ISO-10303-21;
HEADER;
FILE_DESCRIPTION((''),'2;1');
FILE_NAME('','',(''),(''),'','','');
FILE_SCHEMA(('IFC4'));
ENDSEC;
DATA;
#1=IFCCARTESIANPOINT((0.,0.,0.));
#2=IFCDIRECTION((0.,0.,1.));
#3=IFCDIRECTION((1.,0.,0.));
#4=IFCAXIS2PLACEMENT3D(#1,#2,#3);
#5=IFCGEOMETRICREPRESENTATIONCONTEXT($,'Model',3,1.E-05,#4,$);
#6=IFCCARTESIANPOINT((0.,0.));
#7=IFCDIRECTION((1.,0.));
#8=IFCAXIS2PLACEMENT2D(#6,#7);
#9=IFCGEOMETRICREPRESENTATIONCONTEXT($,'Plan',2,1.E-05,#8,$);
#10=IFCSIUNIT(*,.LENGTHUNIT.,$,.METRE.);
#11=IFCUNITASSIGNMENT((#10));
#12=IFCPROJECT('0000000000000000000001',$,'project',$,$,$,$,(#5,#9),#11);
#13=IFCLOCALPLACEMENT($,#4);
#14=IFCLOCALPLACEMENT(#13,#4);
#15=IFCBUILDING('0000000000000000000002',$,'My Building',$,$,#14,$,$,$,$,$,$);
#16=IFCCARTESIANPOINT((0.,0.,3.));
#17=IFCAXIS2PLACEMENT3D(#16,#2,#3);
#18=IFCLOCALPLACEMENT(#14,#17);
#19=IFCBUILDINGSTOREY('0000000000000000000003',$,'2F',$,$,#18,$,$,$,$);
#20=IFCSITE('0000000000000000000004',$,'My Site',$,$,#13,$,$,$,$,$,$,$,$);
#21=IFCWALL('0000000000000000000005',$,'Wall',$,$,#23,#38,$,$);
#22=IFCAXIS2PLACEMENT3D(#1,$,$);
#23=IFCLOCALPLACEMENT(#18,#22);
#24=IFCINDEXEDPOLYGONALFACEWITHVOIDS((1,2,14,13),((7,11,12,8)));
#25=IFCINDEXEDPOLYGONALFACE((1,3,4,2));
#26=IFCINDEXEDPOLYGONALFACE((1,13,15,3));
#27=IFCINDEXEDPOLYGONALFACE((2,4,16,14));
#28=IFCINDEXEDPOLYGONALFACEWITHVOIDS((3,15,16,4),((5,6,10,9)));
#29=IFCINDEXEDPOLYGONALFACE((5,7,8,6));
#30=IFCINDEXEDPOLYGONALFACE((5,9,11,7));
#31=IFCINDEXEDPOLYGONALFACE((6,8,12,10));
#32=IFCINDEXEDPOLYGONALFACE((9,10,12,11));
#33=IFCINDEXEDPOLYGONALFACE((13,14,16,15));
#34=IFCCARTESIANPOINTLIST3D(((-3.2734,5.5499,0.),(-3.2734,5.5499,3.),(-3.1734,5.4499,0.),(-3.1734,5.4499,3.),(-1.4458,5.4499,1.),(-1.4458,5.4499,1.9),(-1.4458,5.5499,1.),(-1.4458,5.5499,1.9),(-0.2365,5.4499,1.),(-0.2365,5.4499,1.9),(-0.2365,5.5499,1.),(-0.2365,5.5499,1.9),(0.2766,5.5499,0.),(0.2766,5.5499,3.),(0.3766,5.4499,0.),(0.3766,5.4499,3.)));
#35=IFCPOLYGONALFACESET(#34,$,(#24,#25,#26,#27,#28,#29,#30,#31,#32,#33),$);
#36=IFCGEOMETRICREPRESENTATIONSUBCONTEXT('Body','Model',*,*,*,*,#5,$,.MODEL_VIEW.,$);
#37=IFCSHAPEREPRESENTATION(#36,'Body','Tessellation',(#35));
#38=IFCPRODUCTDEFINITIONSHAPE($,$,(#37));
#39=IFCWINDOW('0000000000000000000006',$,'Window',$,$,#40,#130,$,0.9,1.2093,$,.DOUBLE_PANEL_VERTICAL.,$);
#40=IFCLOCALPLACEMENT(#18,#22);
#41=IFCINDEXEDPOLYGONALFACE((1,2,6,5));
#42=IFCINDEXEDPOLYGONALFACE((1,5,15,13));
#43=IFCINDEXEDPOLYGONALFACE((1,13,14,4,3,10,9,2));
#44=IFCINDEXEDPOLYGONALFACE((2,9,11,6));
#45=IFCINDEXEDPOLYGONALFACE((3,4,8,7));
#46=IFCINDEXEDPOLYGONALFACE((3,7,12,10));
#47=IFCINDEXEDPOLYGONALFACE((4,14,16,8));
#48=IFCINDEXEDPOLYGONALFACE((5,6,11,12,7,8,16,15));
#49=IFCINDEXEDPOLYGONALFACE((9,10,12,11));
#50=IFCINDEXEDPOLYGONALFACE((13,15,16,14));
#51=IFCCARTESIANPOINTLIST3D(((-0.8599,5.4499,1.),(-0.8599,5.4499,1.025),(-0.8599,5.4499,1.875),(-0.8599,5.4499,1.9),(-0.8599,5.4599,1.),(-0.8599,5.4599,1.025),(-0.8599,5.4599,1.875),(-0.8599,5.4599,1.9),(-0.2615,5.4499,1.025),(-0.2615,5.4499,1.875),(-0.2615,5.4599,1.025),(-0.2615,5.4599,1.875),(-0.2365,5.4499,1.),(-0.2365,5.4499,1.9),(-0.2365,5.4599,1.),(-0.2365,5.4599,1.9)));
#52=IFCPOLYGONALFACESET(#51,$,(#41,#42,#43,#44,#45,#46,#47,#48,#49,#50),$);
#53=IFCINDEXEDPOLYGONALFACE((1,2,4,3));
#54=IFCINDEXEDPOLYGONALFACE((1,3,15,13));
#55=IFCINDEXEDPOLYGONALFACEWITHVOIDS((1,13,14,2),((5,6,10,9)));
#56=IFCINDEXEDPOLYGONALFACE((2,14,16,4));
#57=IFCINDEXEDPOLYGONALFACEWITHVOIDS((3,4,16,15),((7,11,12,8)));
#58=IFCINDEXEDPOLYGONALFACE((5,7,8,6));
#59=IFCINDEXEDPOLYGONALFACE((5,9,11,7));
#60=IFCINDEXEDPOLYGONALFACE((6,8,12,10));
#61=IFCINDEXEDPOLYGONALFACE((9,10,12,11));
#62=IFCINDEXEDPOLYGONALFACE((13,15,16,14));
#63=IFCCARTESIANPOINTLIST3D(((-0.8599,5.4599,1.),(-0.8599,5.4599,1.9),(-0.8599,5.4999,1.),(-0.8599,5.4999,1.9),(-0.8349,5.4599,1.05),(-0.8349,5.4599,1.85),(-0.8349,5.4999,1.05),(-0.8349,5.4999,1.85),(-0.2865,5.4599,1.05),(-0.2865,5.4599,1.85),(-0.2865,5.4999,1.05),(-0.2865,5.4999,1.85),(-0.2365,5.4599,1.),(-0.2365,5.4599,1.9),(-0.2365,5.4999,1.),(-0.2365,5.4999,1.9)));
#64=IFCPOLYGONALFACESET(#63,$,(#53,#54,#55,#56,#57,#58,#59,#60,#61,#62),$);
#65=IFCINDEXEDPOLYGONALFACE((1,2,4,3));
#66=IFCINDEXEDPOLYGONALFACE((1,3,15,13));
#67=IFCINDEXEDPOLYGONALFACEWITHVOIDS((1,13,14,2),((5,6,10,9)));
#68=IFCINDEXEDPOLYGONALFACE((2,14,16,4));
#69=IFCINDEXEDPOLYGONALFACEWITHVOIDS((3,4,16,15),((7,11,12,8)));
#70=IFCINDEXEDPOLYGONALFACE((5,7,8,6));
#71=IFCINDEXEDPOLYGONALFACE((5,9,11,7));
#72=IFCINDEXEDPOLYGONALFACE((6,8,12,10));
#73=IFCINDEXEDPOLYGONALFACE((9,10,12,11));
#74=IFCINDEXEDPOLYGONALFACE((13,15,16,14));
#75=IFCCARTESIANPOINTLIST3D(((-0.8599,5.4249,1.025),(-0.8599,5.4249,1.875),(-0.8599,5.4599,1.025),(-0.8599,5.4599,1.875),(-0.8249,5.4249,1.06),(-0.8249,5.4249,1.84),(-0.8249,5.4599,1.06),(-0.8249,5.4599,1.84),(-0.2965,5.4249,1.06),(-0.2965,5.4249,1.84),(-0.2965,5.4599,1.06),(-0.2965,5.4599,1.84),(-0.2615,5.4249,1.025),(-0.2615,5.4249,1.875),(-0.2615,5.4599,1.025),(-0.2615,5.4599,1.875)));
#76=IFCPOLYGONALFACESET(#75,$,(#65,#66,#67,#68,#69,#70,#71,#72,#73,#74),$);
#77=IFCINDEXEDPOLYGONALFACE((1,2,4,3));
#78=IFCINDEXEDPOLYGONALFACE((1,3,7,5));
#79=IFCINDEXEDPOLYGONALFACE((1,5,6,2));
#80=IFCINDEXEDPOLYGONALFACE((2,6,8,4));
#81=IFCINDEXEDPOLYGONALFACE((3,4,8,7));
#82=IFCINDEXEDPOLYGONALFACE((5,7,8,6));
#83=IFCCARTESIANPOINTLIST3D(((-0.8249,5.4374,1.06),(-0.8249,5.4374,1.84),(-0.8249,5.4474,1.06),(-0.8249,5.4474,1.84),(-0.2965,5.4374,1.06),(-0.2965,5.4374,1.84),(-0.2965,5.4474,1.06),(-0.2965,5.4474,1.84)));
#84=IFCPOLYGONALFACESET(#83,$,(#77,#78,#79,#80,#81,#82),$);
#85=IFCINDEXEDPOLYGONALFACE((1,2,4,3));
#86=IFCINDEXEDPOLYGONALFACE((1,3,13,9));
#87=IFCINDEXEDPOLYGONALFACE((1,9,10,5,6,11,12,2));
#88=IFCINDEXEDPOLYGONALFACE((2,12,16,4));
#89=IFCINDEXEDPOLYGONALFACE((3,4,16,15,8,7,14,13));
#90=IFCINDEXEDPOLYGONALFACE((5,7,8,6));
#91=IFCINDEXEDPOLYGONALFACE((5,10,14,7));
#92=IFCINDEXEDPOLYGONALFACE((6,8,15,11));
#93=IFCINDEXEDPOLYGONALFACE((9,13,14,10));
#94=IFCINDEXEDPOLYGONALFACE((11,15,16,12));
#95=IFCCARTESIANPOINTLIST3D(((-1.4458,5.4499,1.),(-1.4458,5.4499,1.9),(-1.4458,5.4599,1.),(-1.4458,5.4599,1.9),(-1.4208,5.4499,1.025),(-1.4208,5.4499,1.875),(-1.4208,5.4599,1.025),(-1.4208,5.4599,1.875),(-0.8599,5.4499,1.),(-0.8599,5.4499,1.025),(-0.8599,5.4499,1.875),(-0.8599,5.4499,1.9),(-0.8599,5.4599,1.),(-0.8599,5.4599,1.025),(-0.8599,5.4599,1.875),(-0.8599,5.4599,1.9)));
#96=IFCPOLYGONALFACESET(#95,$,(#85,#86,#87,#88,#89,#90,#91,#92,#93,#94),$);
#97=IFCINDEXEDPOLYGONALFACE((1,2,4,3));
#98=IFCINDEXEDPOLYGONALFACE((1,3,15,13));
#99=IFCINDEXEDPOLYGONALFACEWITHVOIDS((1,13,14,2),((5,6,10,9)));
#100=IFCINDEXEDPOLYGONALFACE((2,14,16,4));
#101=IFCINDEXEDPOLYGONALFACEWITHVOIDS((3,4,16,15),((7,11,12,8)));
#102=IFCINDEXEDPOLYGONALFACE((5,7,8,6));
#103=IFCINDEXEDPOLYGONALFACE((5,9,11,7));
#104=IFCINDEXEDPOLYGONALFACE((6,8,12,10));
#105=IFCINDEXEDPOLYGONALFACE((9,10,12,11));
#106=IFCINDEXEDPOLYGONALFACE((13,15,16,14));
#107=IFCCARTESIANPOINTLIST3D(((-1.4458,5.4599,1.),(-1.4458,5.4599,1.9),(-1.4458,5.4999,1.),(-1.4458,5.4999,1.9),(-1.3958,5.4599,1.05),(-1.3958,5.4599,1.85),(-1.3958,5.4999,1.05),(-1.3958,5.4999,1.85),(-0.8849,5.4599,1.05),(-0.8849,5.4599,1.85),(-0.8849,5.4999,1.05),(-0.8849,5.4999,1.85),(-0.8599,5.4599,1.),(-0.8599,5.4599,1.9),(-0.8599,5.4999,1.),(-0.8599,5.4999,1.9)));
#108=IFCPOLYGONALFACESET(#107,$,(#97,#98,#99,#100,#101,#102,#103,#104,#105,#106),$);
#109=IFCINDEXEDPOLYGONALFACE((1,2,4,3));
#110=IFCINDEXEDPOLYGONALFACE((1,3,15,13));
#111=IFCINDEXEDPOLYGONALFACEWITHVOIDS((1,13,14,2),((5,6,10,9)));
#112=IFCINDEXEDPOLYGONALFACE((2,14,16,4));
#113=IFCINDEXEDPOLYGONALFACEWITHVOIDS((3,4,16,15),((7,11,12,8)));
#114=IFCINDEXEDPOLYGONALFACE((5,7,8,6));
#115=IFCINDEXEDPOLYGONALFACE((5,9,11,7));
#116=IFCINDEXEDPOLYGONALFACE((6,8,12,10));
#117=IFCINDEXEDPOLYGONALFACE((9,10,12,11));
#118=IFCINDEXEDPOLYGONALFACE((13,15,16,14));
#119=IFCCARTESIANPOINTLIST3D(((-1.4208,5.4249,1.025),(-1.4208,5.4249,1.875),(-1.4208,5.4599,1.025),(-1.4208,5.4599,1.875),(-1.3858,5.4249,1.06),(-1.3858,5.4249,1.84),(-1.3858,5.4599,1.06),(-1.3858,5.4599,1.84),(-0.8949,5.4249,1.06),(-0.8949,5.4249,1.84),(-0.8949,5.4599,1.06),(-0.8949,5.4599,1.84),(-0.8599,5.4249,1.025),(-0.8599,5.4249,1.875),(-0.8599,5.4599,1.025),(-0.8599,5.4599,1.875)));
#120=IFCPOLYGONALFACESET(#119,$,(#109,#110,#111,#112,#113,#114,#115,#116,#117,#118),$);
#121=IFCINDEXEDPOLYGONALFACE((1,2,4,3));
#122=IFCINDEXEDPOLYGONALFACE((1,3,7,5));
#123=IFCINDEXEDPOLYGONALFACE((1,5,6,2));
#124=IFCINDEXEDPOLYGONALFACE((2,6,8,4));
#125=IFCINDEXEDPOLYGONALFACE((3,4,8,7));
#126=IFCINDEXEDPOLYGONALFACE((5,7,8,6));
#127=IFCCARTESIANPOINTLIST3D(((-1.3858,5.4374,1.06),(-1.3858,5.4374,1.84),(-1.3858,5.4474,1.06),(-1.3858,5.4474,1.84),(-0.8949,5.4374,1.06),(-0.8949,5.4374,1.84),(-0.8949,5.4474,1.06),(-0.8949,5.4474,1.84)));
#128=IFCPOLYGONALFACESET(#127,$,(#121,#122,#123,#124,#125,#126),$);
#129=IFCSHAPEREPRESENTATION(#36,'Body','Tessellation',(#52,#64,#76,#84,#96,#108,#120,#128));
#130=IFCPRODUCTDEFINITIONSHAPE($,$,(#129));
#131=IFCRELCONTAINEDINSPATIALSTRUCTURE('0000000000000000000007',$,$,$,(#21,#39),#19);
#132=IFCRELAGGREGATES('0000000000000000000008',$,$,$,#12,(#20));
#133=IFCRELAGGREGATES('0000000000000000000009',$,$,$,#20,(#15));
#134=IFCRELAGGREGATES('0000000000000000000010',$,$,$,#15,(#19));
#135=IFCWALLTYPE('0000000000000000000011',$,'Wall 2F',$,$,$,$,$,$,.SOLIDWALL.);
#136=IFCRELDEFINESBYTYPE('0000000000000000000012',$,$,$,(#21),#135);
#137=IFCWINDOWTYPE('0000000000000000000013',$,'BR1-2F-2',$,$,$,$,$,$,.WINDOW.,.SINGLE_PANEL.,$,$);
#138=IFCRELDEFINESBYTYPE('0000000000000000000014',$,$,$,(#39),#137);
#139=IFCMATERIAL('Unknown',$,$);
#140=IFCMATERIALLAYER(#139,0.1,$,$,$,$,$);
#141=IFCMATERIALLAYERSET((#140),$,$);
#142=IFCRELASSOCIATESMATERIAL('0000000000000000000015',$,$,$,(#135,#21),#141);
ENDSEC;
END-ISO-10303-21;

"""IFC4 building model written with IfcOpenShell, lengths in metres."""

from ifc_helpers import new_model, entity, si_unit, frame, origin_with_axes, origin_2d_with_axis, place, context, subcontext, project, spatial, line, indexed_curve, outline, extrude, shape, source, transform, mapped, material, layer, layer_set, layer_usage, type_object, type_shapes, element, fill, save


model = new_model("IFC4")

# Units and contexts
model_context = context("Model", 3, precision=1e-05, world=origin_with_axes())
plan_context = context("Plan", 2, precision=1e-05, world=origin_2d_with_axis())
body_context_1 = subcontext(model_context, "Body", "Model", "MODEL_VIEW")
body_context_2 = subcontext(plan_context, "Body", "Plan", "PLAN_VIEW")
ifc_project = project(units=[si_unit("LENGTHUNIT", "METRE")], contexts=[model_context, plan_context])

# Site, building, storey
site_placement = place(None, origin_with_axes())
site = spatial("IfcSite", under=ifc_project, at=site_placement, Name="My Site")
building_placement = place(site_placement, origin_with_axes())
building = spatial("IfcBuilding", under=site, at=building_placement, Name="My Building")
storey_placement = place(building_placement, frame((0.0, 0.0, 3.0), z_axis=(0.0, 0.0, 1.0), x_axis=(1.0, 0.0, 0.0)))
storey = spatial("IfcBuildingStorey", under=building, at=storey_placement, Name="2F")

# Shared definitions
ifc_material = material(Name="Unknown")

# Shared definitions
ifc_layer_1 = layer(ifc_material, 0.1)
ifc_layer_set_1 = layer_set([ifc_layer_1])
wall_type = type_object("IfcWallType", Name="Wall 2F", PredefinedType="SOLIDWALL", material=ifc_layer_set_1)

# Wall, opening, window
ifc_layer_usage_1 = layer_usage(ifc_layer_set_1, "AXIS2", "POSITIVE", 0.0)
wall_1_placement = place(storey_placement, frame((0.2766, 5.5499, 0.0), z_axis=(0.0, 0.0, 1.0), x_axis=(-1.0, 0.0, 0.0)))
wall_1 = element("IfcWall", 1, at=wall_1_placement, inside=storey, type_object=wall_type, material=ifc_layer_usage_1, Name="Wall", context=body_context_1, shape_type="SweptSolid", body=[
    extrude(outline(indexed_curve([(0.0, 0.0), (-0.1, 0.1), (3.45, 0.1), (3.55, 0.0)], segments=[line(1, 2, 3, 4, 1)])), origin_with_axes(), (0.0, 0.0, 1.0), 3.0),
])
shared_shape_1 = source(origin_with_axes(), body_context_1, "Body", "SweptSolid", [
    extrude(outline(indexed_curve([(0.0, 0.0), (1.2093, 0.0), (1.2093, 0.9), (0.0, 0.9)], segments=[line(1, 2, 3, 4, 1)])), frame((0.0, -0.6, 0.0), z_axis=(0.0, -1.0, 0.0), x_axis=(1.0, 0.0, 0.0)), (0.0, 0.0, -1.0), 1.2),
])
opening_1_placement = place(wall_1_placement, frame((0.5131, 0.0, 1.0), z_axis=(0.0, 0.0, 1.0), x_axis=(1.0, 0.0, 0.0)))
opening_1 = element("IfcOpeningElement", 2, at=opening_1_placement, cuts=wall_1, PredefinedType="OPENING", context=body_context_1, shape_type="MappedRepresentation", body=[
    mapped(shared_shape_1, transform((0.0, 0.0, 0.0), x_axis=(1.0, 0.0, 0.0), y_axis=(0.0, 1.0, 0.0), z_axis=(0.0, 0.0, 1.0), scale=1.0)),
])
window_type_1 = type_object("IfcWindowType", Name="BR1-2F-2", PartitioningType="SINGLE_PANEL", PredefinedType="WINDOW")
shared_shape_2 = source(origin_with_axes(), body_context_1, "Body", "SweptSolid", [
    extrude(outline(indexed_curve([(0.6234, 0.0), (0.0, 0.0), (0.0, 0.9), (0.6234, 0.9), (0.6234, 0.875), (0.025, 0.875), (0.025, 0.025), (0.6234, 0.025)], segments=[line(1, 2, 3, 4, 5, 6, 7, 8, 1)])), frame((0.0, 0.09, 0.0), z_axis=(0.0, -1.0, 0.0), x_axis=(1.0, 0.0, 0.0)), (0.0, 0.0, -1.0), 0.01),
    extrude(outline(indexed_curve([(0.0, 0.0), (0.6234, 0.0), (0.6234, 0.9), (0.0, 0.9)], segments=[line(1, 2, 3, 4, 1)]), holes=[indexed_curve([(0.05, 0.05), (0.5984, 0.05), (0.5984, 0.85), (0.05, 0.85)], segments=[line(1, 2, 3, 4, 1)])]), frame((0.0, 0.05, 0.0), z_axis=(0.0, -1.0, 0.0), x_axis=(1.0, 0.0, 0.0)), (0.0, 0.0, -1.0), 0.04),
    extrude(outline(indexed_curve([(0.0, 0.0), (0.5984, 0.0), (0.5984, 0.85), (0.0, 0.85)], segments=[line(1, 2, 3, 4, 1)]), holes=[indexed_curve([(0.035, 0.035), (0.5634, 0.035), (0.5634, 0.815), (0.035, 0.815)], segments=[line(1, 2, 3, 4, 1)])]), frame((0.025, 0.09, 0.025), z_axis=(0.0, -1.0, 0.0), x_axis=(1.0, 0.0, 0.0)), (0.0, 0.0, -1.0), 0.035),
    extrude(outline(indexed_curve([(0.035, 0.035), (0.5634, 0.035), (0.5634, 0.815), (0.035, 0.815)], segments=[line(1, 2, 3, 4, 1)])), frame((0.025, 0.1025, 0.025), z_axis=(0.0, -1.0, 0.0), x_axis=(1.0, 0.0, 0.0)), (0.0, 0.0, -1.0), 0.01),
    extrude(outline(indexed_curve([(0.0, 0.9), (0.5859, 0.9), (0.5859, 0.0), (0.0, 0.0), (0.0, 0.025), (0.5609, 0.025), (0.5609, 0.875), (0.0, 0.875)], segments=[line(1, 2, 3, 4, 5, 6, 7, 8, 1)])), frame((0.6234, 0.09, 0.0), z_axis=(0.0, -1.0, 0.0), x_axis=(1.0, 0.0, 0.0)), (0.0, 0.0, -1.0), 0.01),
    extrude(outline(indexed_curve([(0.0, 0.0), (0.5859, 0.0), (0.5859, 0.9), (0.0, 0.9)], segments=[line(1, 2, 3, 4, 1)]), holes=[indexed_curve([(0.025, 0.05), (0.5359, 0.05), (0.5359, 0.85), (0.025, 0.85)], segments=[line(1, 2, 3, 4, 1)])]), frame((0.6234, 0.05, 0.0), z_axis=(0.0, -1.0, 0.0), x_axis=(1.0, 0.0, 0.0)), (0.0, 0.0, -1.0), 0.04),
    extrude(outline(indexed_curve([(0.0, 0.0), (0.5609, 0.0), (0.5609, 0.85), (0.0, 0.85)], segments=[line(1, 2, 3, 4, 1)]), holes=[indexed_curve([(0.035, 0.035), (0.5259, 0.035), (0.5259, 0.815), (0.035, 0.815)], segments=[line(1, 2, 3, 4, 1)])]), frame((0.6234, 0.09, 0.025), z_axis=(0.0, -1.0, 0.0), x_axis=(1.0, 0.0, 0.0)), (0.0, 0.0, -1.0), 0.035),
    extrude(outline(indexed_curve([(0.035, 0.035), (0.5259, 0.035), (0.5259, 0.815), (0.035, 0.815)], segments=[line(1, 2, 3, 4, 1)])), frame((0.6234, 0.1025, 0.025), z_axis=(0.0, -1.0, 0.0), x_axis=(1.0, 0.0, 0.0)), (0.0, 0.0, -1.0), 0.01),
])
shared_shape_3 = source(origin_with_axes(), body_context_2, "Body", "Curve2D", [
    entity("IfcIndexedPolyCurve", entity("IfcCartesianPointList2D", [[0.05, 0.05], [0.5984, 0.05]])),
    entity("IfcIndexedPolyCurve", entity("IfcCartesianPointList2D", [[0.0, 0.1], [0.025, 0.1], [0.025, 0.09], [0.05, 0.09], [0.05, 0.05], [0.0, 0.05]]), [entity("IfcLineIndex", [1, 2, 3, 4, 5, 6, 1])]),
    entity("IfcIndexedPolyCurve", entity("IfcCartesianPointList2D", [[0.6234, 0.1], [0.6234, 0.1], [0.6234, 0.09], [0.5984, 0.09], [0.5984, 0.05], [0.6234, 0.05]])),
    entity("IfcIndexedPolyCurve", entity("IfcCartesianPointList2D", [[0.025, 0.09], [0.06, 0.09], [0.06, 0.125], [0.025, 0.125]]), [entity("IfcLineIndex", [1, 2, 3, 4, 1])]),
    entity("IfcIndexedPolyCurve", entity("IfcCartesianPointList2D", [[0.6234, 0.09], [0.5884, 0.09], [0.5884, 0.125], [0.6234, 0.125]]), [entity("IfcLineIndex", [1, 2, 3, 4, 1])]),
    entity("IfcIndexedPolyCurve", entity("IfcCartesianPointList2D", [[0.06, 0.09], [0.5884, 0.09]])),
    entity("IfcIndexedPolyCurve", entity("IfcCartesianPointList2D", [[0.06, 0.125], [0.5884, 0.125]])),
    entity("IfcIndexedPolyCurve", entity("IfcCartesianPointList2D", [[0.06, 0.1075], [0.5884, 0.1075]])),
    entity("IfcIndexedPolyCurve", entity("IfcCartesianPointList2D", [[0.6484, 0.05], [1.1593, 0.05]])),
    entity("IfcIndexedPolyCurve", entity("IfcCartesianPointList2D", [[0.6234, 0.1], [0.6234, 0.1], [0.6234, 0.09], [0.6484, 0.09], [0.6484, 0.05], [0.6234, 0.05]])),
    entity("IfcIndexedPolyCurve", entity("IfcCartesianPointList2D", [[1.2093, 0.1], [1.1843, 0.1], [1.1843, 0.09], [1.1593, 0.09], [1.1593, 0.05], [1.2093, 0.05]]), [entity("IfcLineIndex", [1, 2, 3, 4, 5, 6, 1])]),
    entity("IfcIndexedPolyCurve", entity("IfcCartesianPointList2D", [[0.6234, 0.09], [0.6584, 0.09], [0.6584, 0.125], [0.6234, 0.125]]), [entity("IfcLineIndex", [1, 2, 3, 4, 1])]),
    entity("IfcIndexedPolyCurve", entity("IfcCartesianPointList2D", [[1.1843, 0.09], [1.1493, 0.09], [1.1493, 0.125], [1.1843, 0.125]]), [entity("IfcLineIndex", [1, 2, 3, 4, 1])]),
    entity("IfcIndexedPolyCurve", entity("IfcCartesianPointList2D", [[0.6584, 0.09], [1.1493, 0.09]])),
    entity("IfcIndexedPolyCurve", entity("IfcCartesianPointList2D", [[0.6584, 0.125], [1.1493, 0.125]])),
    entity("IfcIndexedPolyCurve", entity("IfcCartesianPointList2D", [[0.6584, 0.1075], [1.1493, 0.1075]])),
])
type_shapes(window_type_1, [shared_shape_2, shared_shape_3])
window_1_placement = place(opening_1_placement, frame((0.0, 0.0, 0.0), z_axis=(0.0, 0.0, 1.0), x_axis=(1.0, 0.0, 0.0)))
window_1 = element("IfcWindow", 3, at=window_1_placement, inside=storey, type_object=window_type_1, Name="Window", OverallHeight=0.9, OverallWidth=1.2093, PartitioningType="DOUBLE_PANEL_VERTICAL", shapes=[
    shape(body_context_1, "Body", "MappedRepresentation", [mapped(shared_shape_2, transform((0.0, 0.0, 0.0), x_axis=(1.0, 0.0, 0.0), y_axis=(0.0, 1.0, 0.0), z_axis=(0.0, 0.0, 1.0), scale=1.0))]),
    shape(body_context_2, "Body", "MappedRepresentation", [mapped(shared_shape_3, transform((0.0, 0.0, 0.0), x_axis=(1.0, 0.0, 0.0), y_axis=(0.0, 1.0, 0.0), z_axis=(0.0, 0.0, 1.0), scale=1.0))]),
])
fill(opening_1, window_1)

save(model, "model.ifc")
